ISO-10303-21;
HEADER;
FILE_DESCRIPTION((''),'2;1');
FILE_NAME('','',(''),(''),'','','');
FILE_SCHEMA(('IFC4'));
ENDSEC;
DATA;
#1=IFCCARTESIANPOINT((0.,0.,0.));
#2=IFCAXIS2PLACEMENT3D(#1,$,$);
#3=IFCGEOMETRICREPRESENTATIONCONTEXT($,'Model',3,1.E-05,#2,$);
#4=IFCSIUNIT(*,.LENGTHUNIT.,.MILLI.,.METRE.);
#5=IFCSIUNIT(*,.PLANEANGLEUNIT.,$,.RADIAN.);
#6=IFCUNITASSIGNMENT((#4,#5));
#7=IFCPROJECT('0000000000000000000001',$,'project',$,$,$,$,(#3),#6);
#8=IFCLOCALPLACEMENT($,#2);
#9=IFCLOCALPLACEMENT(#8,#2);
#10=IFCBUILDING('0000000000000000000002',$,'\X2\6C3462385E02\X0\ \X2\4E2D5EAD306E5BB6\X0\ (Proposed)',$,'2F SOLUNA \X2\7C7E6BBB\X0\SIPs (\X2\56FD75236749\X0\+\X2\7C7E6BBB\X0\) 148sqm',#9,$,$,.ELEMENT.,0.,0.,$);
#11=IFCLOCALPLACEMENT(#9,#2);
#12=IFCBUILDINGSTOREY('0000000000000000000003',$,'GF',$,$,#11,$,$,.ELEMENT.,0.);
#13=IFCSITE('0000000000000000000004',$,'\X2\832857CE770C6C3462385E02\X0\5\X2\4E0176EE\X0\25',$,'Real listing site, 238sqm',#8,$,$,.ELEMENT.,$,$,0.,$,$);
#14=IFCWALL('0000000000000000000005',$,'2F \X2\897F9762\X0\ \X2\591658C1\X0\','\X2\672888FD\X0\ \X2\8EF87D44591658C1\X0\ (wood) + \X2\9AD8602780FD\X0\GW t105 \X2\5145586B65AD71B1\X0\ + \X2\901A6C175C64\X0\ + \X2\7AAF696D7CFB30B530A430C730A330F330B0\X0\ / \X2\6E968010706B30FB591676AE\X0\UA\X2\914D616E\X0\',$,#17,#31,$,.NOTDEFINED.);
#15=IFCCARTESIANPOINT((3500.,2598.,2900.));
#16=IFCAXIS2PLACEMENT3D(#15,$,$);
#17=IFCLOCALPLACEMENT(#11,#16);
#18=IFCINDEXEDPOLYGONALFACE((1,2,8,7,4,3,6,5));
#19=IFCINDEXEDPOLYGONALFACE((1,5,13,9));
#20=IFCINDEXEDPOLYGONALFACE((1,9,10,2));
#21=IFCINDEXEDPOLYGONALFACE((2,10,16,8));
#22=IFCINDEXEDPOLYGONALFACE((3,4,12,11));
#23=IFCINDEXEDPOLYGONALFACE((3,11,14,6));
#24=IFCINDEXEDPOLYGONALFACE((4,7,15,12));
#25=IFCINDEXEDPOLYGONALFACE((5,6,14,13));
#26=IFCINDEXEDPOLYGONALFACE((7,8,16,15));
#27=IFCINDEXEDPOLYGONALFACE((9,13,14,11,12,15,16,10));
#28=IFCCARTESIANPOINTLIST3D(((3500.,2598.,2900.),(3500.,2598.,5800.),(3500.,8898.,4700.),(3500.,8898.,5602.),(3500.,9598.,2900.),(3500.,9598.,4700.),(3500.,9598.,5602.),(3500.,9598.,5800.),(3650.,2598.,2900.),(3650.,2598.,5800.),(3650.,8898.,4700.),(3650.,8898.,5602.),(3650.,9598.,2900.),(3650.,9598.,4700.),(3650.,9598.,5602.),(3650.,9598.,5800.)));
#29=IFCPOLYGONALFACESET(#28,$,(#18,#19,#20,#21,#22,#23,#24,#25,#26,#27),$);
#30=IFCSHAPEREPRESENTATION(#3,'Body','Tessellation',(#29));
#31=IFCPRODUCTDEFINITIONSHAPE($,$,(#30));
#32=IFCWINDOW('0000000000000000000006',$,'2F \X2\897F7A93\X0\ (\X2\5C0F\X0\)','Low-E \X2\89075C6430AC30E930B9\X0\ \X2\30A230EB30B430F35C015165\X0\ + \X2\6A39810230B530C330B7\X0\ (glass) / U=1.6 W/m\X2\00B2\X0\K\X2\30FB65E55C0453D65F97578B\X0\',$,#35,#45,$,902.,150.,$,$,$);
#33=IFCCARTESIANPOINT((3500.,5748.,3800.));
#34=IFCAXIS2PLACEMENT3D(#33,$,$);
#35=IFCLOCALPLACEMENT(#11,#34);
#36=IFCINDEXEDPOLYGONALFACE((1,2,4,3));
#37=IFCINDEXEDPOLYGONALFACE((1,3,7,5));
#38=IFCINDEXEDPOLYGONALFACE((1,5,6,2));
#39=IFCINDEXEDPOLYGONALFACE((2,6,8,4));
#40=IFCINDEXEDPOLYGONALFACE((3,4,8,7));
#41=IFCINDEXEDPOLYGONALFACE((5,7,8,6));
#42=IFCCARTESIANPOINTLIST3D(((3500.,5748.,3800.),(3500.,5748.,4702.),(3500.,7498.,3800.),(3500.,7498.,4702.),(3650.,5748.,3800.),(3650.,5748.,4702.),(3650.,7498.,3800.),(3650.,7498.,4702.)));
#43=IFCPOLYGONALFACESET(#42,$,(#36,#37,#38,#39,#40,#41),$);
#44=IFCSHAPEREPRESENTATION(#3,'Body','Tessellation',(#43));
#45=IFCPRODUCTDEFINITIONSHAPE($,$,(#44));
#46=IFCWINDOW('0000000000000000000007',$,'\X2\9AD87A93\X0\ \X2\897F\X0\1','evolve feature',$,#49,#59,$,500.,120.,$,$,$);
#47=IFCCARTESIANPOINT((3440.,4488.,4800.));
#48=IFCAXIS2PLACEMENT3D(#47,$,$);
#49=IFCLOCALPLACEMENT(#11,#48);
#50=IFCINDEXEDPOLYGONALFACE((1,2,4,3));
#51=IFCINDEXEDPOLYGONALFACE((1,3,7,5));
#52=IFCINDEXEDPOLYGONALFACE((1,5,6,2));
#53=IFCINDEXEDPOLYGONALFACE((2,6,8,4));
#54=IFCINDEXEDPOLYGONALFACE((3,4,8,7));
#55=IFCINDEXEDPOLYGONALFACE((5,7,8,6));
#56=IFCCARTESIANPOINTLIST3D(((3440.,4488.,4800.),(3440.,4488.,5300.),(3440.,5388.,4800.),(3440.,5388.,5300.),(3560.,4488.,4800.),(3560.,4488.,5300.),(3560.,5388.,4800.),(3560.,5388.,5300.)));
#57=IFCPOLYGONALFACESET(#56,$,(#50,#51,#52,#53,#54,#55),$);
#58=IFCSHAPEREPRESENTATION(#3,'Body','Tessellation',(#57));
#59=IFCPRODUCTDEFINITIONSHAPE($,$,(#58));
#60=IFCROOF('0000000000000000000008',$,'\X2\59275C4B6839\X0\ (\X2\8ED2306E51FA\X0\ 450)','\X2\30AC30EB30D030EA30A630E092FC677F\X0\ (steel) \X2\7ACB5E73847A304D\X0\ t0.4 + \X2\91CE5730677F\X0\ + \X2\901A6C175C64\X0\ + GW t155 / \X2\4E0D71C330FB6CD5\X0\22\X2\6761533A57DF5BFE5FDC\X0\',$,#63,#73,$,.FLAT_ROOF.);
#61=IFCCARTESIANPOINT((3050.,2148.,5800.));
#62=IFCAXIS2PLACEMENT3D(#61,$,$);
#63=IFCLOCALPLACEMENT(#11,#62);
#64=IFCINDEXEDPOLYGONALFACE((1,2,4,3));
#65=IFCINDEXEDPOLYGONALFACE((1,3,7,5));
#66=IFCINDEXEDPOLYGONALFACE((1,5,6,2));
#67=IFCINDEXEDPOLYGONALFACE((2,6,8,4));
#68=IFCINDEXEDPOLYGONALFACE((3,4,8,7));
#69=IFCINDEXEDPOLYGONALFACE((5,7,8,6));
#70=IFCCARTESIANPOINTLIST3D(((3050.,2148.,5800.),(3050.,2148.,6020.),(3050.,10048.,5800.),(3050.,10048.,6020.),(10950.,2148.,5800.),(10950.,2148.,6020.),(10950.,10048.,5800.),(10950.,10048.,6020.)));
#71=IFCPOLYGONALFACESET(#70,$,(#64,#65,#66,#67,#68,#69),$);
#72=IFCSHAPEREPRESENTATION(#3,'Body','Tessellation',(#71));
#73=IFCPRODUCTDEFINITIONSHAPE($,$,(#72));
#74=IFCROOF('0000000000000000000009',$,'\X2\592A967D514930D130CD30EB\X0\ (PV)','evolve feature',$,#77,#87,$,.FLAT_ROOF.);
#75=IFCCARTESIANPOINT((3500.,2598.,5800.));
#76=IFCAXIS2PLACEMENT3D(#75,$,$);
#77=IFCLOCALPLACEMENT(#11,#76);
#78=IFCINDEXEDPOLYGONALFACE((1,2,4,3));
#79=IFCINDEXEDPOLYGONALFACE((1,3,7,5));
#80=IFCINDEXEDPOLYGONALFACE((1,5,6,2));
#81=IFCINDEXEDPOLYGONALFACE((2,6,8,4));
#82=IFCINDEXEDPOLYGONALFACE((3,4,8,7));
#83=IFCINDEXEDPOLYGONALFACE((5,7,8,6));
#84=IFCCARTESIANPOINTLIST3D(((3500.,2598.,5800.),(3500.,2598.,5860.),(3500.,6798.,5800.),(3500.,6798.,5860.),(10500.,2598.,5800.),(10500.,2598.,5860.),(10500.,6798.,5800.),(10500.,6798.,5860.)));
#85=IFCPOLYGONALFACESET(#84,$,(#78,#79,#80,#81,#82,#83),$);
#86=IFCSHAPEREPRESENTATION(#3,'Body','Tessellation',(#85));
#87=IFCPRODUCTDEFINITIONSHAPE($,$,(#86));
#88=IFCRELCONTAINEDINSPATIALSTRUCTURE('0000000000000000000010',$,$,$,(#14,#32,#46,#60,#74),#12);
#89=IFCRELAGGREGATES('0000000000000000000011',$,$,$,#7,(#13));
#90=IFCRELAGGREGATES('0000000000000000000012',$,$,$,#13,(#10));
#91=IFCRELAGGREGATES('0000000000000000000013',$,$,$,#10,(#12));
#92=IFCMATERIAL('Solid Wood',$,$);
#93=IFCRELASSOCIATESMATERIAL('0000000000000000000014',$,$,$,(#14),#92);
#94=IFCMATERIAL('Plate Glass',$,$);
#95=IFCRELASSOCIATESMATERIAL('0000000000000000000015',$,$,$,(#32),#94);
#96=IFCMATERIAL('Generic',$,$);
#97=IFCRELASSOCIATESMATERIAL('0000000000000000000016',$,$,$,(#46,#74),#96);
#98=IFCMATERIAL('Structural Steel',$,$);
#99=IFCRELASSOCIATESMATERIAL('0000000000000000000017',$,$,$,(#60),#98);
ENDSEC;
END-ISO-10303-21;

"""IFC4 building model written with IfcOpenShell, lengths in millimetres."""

from ifc_helpers import new_model, si_unit, frame, frame_2d, origin, place, context, project, spatial, rectangle, extrude, material, element, fill, save


model = new_model("IFC4")

# Units and contexts
model_context = context("Model", 3, precision=1e-05, world=origin())
ifc_project = project(units=[si_unit("LENGTHUNIT", "METRE", prefix="MILLI"), si_unit("PLANEANGLEUNIT", "RADIAN")], contexts=[model_context])

# Site, building, storey
site_placement = place(None, origin())
site = spatial("IfcSite", under=ifc_project, at=site_placement, Name="茨城県水戸市5丁目25", ObjectType="Real listing site, 238sqm", CompositionType="ELEMENT", RefElevation=0.0)
building_placement = place(site_placement, origin())
building = spatial("IfcBuilding", under=site, at=building_placement, Name="水戸市 中庭の家 (Proposed)", ObjectType="2F SOLUNA 籾殻SIPs (国産杉+籾殻) 148sqm", CompositionType="ELEMENT", ElevationOfRefHeight=0.0, ElevationOfTerrain=0.0)
storey_placement = place(building_placement, origin())
storey = spatial("IfcBuildingStorey", under=building, at=storey_placement, Name="GF", CompositionType="ELEMENT", Elevation=0.0)

# Shared definitions
ifc_material_1 = material(Name="Solid Wood")
ifc_material_2 = material(Name="Generic")

# Shared definitions
ifc_material_3 = material(Name="Plate Glass")

# Wall, openings, windows
wall_1_placement = place(storey_placement, frame((3500.0, 2598.0, 2900.0)))
wall_1 = element("IfcWall", 1, at=wall_1_placement, inside=storey, material=ifc_material_1, Name="2F 西面 外壁", Description="木製 軸組外壁 (wood) + 高性能GW t105 充填断熱 + 通気層 + 窯業系サイディング / 準耐火・外皮UA配慮", PredefinedType="NOTDEFINED", context=model_context, shape_type="SweptSolid", body=[
    extrude(rectangle(XDim=150.0, YDim=7000.0, at=frame_2d((75.0, 3500.0))), frame((3500.0, 2598.0, 2900.0)), (0.0, 0.0, 1.0), 2900.0),
])
opening_1_placement = place(storey_placement, frame((3500.0, 5748.0, 3800.0)))
opening_1 = element("IfcOpeningElement", 2, at=opening_1_placement, cuts=wall_1, PredefinedType="NOTDEFINED", context=model_context, shape_type="SweptSolid", body=[
    extrude(rectangle(XDim=150.0, YDim=1750.0, at=frame_2d((75.0, 875.0))), frame((3500.0, 5748.0, 3800.0)), (0.0, 0.0, 1.0), 902.0),
])
opening_2_placement = place(storey_placement, frame((3440.0, 4488.0, 4800.0)))
opening_2 = element("IfcOpeningElement", 3, at=opening_2_placement, cuts=wall_1, PredefinedType="NOTDEFINED", context=model_context, shape_type="SweptSolid", body=[
    extrude(rectangle(XDim=120.0, YDim=900.0, at=frame_2d((60.0, 450.0))), frame((3440.0, 4488.0, 4800.0)), (0.0, 0.0, 1.0), 500.0),
])
window_1_placement = place(storey_placement, frame((3500.0, 5748.0, 3800.0)))
window_1 = element("IfcWindow", 4, at=window_1_placement, inside=storey, material=ifc_material_3, Name="2F 西窓 (小)", Description="Low-E 複層ガラス アルゴン封入 + 樹脂サッシ (glass) / U=1.6 W/m²K・日射取得型", OverallHeight=902.0, OverallWidth=150.0, context=model_context, shape_type="SweptSolid", body=[
    extrude(rectangle(XDim=150.0, YDim=1750.0, at=frame_2d((75.0, 875.0))), frame((3500.0, 5748.0, 3800.0)), (0.0, 0.0, 1.0), 902.0),
])
fill(opening_1, window_1)
window_2_placement = place(storey_placement, frame((3440.0, 4488.0, 4800.0)))
window_2 = element("IfcWindow", 5, at=window_2_placement, inside=storey, material=ifc_material_2, Name="高窓 西1", Description="evolve feature", OverallHeight=500.0, OverallWidth=120.0, context=model_context, shape_type="SweptSolid", body=[
    extrude(rectangle(XDim=120.0, YDim=900.0, at=frame_2d((60.0, 450.0))), frame((3440.0, 4488.0, 4800.0)), (0.0, 0.0, 1.0), 500.0),
])
fill(opening_2, window_2)

# Roofs
ifc_material_4 = material(Name="Structural Steel")
roof_1_placement = place(storey_placement, frame((3050.0, 2148.0, 5800.0)))
element("IfcRoof", 6, at=roof_1_placement, inside=storey, material=ifc_material_4, Name="大屋根 (軒の出 450)", Description="ガルバリウム鋼板 (steel) 立平葺き t0.4 + 野地板 + 通気層 + GW t155 / 不燃・法22条区域対応", PredefinedType="FLAT_ROOF", context=model_context, shape_type="SweptSolid", body=[
    extrude(rectangle(XDim=7900.0, YDim=7900.0, at=frame_2d((3950.0, 3950.0))), frame((3050.0, 2148.0, 5800.0)), (0.0, 0.0, 1.0), 220.0),
])
roof_2_placement = place(storey_placement, frame((3500.0, 2598.0, 5800.0)))
element("IfcRoof", 7, at=roof_2_placement, inside=storey, material=ifc_material_2, Name="太陽光パネル (PV)", Description="evolve feature", PredefinedType="FLAT_ROOF", context=model_context, shape_type="SweptSolid", body=[
    extrude(rectangle(XDim=7000.0, YDim=4200.0, at=frame_2d((3500.0, 2100.0))), frame((3500.0, 2598.0, 5800.0)), (0.0, 0.0, 1.0), 60.0),
])

save(model, "model.ifc")
